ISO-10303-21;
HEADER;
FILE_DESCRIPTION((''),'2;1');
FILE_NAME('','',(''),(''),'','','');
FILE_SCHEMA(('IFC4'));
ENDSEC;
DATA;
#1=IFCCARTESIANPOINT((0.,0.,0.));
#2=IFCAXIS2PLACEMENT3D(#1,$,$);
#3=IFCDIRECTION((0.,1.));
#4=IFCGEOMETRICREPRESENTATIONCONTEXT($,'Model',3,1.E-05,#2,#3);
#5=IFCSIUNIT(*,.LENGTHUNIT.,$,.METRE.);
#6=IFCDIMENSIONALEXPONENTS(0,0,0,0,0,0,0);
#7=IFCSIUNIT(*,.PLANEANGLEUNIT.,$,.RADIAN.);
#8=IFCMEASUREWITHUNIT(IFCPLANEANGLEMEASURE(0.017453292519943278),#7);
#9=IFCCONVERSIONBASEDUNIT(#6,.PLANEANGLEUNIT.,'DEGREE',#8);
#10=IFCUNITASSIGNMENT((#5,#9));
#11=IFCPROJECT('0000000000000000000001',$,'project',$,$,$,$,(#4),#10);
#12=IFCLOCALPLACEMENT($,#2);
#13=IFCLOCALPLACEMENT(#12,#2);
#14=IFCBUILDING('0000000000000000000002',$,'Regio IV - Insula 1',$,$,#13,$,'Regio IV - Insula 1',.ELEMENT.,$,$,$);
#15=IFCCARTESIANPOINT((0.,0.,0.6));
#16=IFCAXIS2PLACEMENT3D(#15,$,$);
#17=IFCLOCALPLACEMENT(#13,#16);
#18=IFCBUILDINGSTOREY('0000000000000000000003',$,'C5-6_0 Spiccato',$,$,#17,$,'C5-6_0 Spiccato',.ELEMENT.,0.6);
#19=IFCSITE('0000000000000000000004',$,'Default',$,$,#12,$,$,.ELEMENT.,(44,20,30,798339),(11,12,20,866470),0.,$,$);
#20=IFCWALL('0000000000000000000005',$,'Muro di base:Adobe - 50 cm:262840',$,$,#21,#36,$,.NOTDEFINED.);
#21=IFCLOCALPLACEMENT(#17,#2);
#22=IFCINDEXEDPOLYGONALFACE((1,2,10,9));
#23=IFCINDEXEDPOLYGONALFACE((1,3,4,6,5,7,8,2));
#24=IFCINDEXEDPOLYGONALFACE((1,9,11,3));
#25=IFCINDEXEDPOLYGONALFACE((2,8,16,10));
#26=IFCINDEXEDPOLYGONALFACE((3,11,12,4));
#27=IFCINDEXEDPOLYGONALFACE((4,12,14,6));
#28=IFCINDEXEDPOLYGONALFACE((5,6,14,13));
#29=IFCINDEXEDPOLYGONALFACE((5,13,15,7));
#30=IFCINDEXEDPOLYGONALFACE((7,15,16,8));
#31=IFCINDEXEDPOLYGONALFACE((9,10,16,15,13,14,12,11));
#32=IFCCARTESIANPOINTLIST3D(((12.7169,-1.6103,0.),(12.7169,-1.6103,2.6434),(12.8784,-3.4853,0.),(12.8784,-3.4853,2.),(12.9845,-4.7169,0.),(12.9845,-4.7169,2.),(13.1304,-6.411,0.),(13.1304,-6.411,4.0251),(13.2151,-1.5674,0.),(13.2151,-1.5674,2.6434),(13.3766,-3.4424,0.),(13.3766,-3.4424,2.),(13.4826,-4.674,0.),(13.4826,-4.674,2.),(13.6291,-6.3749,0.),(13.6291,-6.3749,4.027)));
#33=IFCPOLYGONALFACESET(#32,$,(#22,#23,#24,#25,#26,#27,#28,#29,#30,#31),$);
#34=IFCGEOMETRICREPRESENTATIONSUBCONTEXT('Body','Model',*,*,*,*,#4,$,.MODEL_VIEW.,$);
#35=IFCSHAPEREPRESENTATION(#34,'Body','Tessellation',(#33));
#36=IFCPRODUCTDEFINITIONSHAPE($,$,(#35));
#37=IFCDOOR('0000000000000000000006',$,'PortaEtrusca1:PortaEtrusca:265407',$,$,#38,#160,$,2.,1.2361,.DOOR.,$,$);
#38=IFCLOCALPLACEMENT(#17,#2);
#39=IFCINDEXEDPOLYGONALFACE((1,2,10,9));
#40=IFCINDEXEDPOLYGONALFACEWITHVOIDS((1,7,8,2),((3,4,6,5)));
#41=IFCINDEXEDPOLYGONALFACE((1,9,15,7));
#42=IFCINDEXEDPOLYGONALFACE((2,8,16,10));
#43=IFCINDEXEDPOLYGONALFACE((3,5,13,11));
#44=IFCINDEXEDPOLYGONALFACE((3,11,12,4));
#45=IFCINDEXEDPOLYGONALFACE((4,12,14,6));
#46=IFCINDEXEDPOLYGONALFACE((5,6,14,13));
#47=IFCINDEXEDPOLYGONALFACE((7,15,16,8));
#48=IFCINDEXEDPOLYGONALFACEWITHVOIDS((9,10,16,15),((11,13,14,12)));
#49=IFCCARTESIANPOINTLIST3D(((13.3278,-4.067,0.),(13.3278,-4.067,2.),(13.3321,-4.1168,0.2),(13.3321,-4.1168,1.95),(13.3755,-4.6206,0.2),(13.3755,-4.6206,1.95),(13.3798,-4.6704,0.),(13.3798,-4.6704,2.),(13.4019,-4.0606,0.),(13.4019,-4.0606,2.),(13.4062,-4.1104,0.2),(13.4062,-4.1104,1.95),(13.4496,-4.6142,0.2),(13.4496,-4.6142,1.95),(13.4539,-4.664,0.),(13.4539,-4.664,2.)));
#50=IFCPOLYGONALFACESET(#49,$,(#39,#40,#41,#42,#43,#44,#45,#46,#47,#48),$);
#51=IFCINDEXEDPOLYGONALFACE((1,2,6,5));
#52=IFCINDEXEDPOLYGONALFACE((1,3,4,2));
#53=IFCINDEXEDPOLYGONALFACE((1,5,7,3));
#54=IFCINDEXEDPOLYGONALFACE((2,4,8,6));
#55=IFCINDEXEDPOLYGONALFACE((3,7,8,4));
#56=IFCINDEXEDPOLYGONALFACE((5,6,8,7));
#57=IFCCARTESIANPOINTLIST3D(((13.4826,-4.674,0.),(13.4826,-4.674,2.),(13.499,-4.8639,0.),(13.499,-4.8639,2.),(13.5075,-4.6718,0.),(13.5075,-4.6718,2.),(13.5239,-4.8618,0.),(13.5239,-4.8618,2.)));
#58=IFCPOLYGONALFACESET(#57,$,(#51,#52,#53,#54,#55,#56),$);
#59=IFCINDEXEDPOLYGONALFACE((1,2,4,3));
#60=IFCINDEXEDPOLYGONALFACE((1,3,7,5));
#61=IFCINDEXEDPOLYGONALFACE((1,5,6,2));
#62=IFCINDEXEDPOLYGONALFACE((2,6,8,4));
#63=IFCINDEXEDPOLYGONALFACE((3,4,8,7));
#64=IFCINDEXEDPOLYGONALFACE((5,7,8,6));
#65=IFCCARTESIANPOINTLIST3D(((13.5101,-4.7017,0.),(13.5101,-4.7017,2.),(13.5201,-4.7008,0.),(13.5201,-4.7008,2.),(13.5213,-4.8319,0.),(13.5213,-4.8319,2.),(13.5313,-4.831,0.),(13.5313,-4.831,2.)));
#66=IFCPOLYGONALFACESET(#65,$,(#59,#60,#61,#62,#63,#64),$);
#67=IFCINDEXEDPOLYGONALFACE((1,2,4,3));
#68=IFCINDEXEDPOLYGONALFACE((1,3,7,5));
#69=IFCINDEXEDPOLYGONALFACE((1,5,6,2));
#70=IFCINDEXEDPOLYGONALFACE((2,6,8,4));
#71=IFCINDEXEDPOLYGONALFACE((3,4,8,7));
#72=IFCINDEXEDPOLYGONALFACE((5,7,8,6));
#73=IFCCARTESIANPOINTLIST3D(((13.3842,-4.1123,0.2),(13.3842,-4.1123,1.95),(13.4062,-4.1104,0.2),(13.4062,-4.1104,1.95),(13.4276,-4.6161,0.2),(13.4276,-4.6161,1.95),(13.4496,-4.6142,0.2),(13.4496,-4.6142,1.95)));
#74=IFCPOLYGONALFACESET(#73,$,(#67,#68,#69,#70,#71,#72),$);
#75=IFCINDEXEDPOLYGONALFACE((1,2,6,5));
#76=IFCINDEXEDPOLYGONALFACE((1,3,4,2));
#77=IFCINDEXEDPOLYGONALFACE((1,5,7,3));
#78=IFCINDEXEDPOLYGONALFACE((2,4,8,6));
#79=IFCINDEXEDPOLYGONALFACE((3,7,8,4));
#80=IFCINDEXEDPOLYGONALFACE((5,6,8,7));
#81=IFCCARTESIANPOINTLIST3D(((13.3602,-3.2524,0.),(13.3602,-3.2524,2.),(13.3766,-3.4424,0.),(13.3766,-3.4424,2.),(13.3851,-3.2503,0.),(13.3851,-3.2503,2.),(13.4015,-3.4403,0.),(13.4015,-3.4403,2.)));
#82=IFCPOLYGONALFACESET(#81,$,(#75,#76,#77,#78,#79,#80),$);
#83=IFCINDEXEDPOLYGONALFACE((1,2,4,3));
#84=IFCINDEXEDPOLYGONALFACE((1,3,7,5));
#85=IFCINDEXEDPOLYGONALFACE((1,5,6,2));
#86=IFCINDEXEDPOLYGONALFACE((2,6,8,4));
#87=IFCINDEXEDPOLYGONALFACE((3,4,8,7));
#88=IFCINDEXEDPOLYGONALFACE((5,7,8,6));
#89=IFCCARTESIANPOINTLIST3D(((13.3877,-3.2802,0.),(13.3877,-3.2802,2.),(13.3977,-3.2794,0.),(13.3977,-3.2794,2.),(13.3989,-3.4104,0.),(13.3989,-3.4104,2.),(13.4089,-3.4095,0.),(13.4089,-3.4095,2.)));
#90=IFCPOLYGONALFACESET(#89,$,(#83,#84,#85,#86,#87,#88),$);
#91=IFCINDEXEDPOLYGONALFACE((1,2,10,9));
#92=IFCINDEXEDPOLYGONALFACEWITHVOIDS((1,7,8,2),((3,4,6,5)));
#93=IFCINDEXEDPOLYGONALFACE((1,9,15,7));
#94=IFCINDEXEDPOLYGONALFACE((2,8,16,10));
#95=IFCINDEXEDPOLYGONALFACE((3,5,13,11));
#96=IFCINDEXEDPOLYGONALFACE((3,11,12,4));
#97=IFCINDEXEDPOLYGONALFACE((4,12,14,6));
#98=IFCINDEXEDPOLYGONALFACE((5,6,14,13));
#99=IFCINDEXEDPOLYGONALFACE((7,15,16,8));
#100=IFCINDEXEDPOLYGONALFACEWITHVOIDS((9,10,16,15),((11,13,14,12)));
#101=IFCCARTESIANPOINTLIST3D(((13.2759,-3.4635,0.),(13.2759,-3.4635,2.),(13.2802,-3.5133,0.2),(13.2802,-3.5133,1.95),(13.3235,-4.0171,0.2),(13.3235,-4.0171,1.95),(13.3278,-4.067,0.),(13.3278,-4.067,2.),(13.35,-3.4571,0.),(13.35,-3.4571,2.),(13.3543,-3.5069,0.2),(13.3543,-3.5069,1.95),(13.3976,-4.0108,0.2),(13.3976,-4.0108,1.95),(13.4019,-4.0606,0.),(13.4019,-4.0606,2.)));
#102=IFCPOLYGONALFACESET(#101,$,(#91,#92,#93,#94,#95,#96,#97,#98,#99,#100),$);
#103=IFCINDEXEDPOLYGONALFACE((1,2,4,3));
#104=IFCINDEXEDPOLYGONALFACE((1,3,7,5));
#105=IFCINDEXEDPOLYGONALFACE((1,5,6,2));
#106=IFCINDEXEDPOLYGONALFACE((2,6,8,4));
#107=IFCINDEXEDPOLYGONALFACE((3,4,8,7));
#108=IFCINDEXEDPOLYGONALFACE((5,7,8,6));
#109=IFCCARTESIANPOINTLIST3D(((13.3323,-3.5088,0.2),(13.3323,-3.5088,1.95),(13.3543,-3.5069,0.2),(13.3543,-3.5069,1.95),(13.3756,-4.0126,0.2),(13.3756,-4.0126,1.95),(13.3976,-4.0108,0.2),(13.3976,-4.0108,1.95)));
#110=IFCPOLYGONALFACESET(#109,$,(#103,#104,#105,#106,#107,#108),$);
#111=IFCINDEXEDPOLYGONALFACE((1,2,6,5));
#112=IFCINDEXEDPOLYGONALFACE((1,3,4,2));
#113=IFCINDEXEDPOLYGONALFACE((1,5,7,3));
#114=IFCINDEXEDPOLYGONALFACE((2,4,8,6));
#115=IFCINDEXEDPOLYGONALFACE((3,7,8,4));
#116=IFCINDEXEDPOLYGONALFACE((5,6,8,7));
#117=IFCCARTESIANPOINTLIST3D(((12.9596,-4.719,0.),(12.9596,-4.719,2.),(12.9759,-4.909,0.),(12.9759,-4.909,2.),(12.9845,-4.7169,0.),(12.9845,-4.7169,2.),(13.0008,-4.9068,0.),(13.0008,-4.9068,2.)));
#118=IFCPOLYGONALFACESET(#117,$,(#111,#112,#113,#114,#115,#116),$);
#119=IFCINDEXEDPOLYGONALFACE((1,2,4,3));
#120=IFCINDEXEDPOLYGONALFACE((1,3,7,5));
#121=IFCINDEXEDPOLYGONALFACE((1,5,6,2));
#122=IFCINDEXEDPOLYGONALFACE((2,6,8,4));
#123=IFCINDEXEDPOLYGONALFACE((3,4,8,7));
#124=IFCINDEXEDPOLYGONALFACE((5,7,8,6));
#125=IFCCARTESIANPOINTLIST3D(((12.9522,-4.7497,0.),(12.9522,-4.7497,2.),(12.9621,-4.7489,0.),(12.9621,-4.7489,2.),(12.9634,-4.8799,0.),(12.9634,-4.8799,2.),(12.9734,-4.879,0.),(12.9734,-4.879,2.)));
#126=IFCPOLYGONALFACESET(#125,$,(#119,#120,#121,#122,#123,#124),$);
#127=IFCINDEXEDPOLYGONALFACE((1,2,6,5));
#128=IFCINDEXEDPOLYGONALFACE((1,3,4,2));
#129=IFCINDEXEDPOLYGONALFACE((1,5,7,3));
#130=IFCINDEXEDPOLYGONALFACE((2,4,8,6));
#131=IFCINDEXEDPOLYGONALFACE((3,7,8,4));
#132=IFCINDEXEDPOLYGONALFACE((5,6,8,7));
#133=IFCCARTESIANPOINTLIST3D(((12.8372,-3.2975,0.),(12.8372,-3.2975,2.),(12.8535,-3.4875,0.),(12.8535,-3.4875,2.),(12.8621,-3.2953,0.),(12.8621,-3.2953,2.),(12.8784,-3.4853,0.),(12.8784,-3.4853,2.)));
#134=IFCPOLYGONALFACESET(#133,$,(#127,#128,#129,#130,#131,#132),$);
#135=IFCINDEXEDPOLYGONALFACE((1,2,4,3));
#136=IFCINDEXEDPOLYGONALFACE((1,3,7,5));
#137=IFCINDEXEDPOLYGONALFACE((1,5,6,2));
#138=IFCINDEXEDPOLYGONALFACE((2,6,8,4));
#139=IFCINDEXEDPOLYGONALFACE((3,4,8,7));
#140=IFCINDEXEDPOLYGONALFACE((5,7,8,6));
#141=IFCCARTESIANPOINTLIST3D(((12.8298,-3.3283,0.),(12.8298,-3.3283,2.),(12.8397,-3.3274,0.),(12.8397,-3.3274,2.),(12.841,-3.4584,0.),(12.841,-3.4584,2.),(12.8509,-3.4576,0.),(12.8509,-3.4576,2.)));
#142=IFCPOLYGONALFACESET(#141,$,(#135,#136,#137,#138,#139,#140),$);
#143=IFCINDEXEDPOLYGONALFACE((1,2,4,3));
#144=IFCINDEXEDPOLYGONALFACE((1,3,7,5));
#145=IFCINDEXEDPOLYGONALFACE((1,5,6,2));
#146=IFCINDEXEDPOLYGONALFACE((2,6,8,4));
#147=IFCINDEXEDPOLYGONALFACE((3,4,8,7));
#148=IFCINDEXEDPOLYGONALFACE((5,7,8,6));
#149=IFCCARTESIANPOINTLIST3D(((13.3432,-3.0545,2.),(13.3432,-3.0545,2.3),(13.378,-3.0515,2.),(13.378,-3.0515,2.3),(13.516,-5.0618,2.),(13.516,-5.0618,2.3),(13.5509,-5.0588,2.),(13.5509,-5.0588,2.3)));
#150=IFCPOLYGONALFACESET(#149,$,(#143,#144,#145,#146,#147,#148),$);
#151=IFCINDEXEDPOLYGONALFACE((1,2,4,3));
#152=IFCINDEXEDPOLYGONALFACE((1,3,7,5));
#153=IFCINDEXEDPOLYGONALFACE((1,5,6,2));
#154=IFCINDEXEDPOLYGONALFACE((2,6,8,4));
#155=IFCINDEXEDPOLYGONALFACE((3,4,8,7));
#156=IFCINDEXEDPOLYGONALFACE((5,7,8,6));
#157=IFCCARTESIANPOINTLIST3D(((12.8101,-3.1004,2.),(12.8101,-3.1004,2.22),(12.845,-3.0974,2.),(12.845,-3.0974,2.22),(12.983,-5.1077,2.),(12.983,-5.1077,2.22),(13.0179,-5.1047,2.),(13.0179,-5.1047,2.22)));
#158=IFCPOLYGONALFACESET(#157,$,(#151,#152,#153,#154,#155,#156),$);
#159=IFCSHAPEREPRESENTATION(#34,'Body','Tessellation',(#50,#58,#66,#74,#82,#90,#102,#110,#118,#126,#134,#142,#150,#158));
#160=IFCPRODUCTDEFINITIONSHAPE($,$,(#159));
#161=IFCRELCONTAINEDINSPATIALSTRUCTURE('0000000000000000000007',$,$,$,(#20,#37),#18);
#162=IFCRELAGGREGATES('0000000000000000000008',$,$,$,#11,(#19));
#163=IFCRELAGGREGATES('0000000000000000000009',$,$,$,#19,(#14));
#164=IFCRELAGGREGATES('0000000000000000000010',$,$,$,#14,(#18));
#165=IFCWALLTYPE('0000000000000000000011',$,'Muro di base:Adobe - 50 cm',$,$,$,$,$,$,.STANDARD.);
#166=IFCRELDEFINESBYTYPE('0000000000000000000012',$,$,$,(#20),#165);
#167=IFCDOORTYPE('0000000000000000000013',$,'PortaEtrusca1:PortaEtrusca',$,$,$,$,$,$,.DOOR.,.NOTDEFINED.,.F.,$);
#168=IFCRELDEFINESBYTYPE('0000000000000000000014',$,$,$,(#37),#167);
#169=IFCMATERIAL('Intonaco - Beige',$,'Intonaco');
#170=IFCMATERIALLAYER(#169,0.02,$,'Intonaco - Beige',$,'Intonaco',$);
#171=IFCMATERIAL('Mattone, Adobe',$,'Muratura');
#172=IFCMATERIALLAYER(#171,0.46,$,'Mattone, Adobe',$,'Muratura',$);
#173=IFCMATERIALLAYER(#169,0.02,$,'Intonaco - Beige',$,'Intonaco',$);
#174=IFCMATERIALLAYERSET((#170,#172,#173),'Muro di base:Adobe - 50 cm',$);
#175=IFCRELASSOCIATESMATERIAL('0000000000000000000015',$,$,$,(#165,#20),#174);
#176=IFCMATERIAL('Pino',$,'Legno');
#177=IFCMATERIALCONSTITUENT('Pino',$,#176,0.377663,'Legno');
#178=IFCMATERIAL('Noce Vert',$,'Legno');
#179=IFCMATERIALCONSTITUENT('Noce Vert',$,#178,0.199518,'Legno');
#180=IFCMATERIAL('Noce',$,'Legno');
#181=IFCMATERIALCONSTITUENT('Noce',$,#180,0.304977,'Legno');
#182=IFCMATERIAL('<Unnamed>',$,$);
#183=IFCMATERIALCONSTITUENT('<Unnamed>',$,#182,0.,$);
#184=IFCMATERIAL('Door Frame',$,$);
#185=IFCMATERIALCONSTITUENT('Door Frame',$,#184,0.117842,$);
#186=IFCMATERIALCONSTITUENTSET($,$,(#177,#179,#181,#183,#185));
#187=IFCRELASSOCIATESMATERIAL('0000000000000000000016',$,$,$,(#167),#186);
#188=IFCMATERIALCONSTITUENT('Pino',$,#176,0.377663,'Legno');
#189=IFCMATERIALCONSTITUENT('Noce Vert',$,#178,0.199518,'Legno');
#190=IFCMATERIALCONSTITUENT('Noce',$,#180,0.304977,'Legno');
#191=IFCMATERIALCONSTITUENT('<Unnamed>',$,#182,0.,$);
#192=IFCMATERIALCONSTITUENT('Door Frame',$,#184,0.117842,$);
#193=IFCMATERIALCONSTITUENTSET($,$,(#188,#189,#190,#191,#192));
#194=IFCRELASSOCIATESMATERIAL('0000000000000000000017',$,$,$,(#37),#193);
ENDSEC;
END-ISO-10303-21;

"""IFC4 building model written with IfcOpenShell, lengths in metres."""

from ifc_helpers import new_model, entity, si_unit, converted_unit, direction, frame, frame_2d, origin, origin_2d_with_axis, place, context, subcontext, project, spatial, polyline, rectangle, outline, extrude, clip, bounded_halfspace, source, transform, mapped, material, layer, layer_set, layer_usage, constituent, constituent_set, type_object, type_shapes, element, fill, save


model = new_model("IFC4")

# Units and contexts
model_context = context("Model", 3, precision=1e-05, world=origin(), true_north=direction((0.0, 1.0)))
body_context = subcontext(model_context, "Body", "Model", "MODEL_VIEW")
ifc_project = project(units=[si_unit("LENGTHUNIT", "METRE"), converted_unit("PLANEANGLEUNIT", "DEGREE", entity("IfcPlaneAngleMeasure", 0.017453292519943278), si_unit("PLANEANGLEUNIT", "RADIAN"), dimensions=[0, 0, 0, 0, 0, 0, 0])], contexts=[model_context])

# Site, building, storey
site_placement = place(None, origin())
site = spatial("IfcSite", under=ifc_project, at=site_placement, Name="Default", CompositionType="ELEMENT", RefLatitude=(44, 20, 30, 798339), RefLongitude=(11, 12, 20, 866470), RefElevation=0.0)
building_placement = place(site_placement, origin())
building = spatial("IfcBuilding", under=site, at=building_placement, Name="Regio IV - Insula 1", LongName="Regio IV - Insula 1", CompositionType="ELEMENT")
storey_placement = place(building_placement, frame((0.0, 0.0, 0.6)))
storey = spatial("IfcBuildingStorey", under=building, at=storey_placement, Name="C5-6_0 Spiccato", LongName="C5-6_0 Spiccato", CompositionType="ELEMENT", Elevation=0.6)

# Shared definitions
ifc_material_1 = material(Name="Intonaco - Beige", Category="Intonaco")
ifc_material_2 = material(Name="Mattone, Adobe", Category="Muratura")
ifc_layer_1 = layer(ifc_material_1, 0.02, Name="Intonaco - Beige", Category="Intonaco")
ifc_layer_2 = layer(ifc_material_2, 0.46, Name="Mattone, Adobe", Category="Muratura")
ifc_layer_3 = layer(ifc_material_1, 0.02, Name="Intonaco - Beige", Category="Intonaco")
ifc_layer_set_1 = layer_set([ifc_layer_1, ifc_layer_2, ifc_layer_3], Name="Muro di base:Adobe - 50 cm")
wall_type_1 = type_object("IfcWallType", Name="Muro di base:Adobe - 50 cm", PredefinedType="STANDARD", material=ifc_layer_set_1)

# Shared definitions
ifc_material_3 = material(Name="Pino", Category="Legno")
ifc_material_4 = material(Name="Noce Vert", Category="Legno")
ifc_material_5 = material(Name="Noce", Category="Legno")
ifc_material_6 = material(Name="<Unnamed>")
ifc_material_7 = material(Name="Door Frame")
ifc_constituent_1 = constituent(ifc_material_3, Name="Pino", Category="Legno", fraction=0.377663)
ifc_constituent_2 = constituent(ifc_material_4, Name="Noce Vert", Category="Legno", fraction=0.199518)
ifc_constituent_3 = constituent(ifc_material_5, Name="Noce", Category="Legno", fraction=0.304977)
ifc_constituent_4 = constituent(ifc_material_6, Name="<Unnamed>", fraction=0.0)
ifc_constituent_5 = constituent(ifc_material_7, Name="Door Frame", fraction=0.117842)
ifc_constituent_set_1 = constituent_set(constituents=[ifc_constituent_1, ifc_constituent_2, ifc_constituent_3, ifc_constituent_4, ifc_constituent_5])
door_type = type_object("IfcDoorType", Name="PortaEtrusca1:PortaEtrusca", OperationType="NOTDEFINED", ParameterTakesPrecedence=False, PredefinedType="DOOR", material=ifc_constituent_set_1)
shared_shape = source(origin(), body_context, "Body", "SweptSolid", [
    extrude(outline(polyline([(-1.0, -0.3028), (1.0, -0.3028), (1.0, 0.3028), (-1.0, 0.3028), (-1.0, -0.3028)]), holes=[polyline([(-0.95, 0.2528), (0.8, 0.2528), (0.8, -0.2528), (-0.95, -0.2528), (-0.95, 0.2528)])]), frame((0.3152, 0.0278, 1.0), z_axis=(0.0, 1.0, 0.0), x_axis=(0.0, 0.0, -1.0)), (0.0, 0.0, 1.0), 0.0744),
    extrude(rectangle(XDim=0.025, YDim=0.1907, at=frame_2d((0.0, 0.0), x_axis=(1.0, 0.0))), frame((-0.0953, -0.0125, 0.0), z_axis=(0.0, 0.0, 1.0), x_axis=(0.0, 1.0, 0.0)), (0.0, 0.0, 1.0), 2.0),
    extrude(rectangle(XDim=0.01, YDim=0.1306, at=frame_2d((0.0, 0.0), x_axis=(1.0, 0.0))), frame((-0.0953, -0.03, 0.0), z_axis=(0.0, 0.0, 1.0), x_axis=(0.0, 1.0, 0.0)), (0.0, 0.0, 1.0), 2.0),
    extrude(rectangle(XDim=0.0221, YDim=0.5057, at=frame_2d((0.0, 0.0), x_axis=(1.0, 0.0))), frame((0.3152, 0.0388, 0.2), z_axis=(0.0, 0.0, 1.0), x_axis=(0.0, 1.0, 0.0)), (0.0, 0.0, 1.0), 1.75),
    extrude(rectangle(XDim=0.025, YDim=0.1907, at=frame_2d((0.0, 0.0), x_axis=(1.0, 0.0))), frame((1.3314, -0.0125, 0.0), z_axis=(0.0, 0.0, 1.0), x_axis=(0.0, 1.0, 0.0)), (0.0, 0.0, 1.0), 2.0),
    extrude(rectangle(XDim=0.01, YDim=0.1306, at=frame_2d((0.0, 0.0), x_axis=(1.0, 0.0))), frame((1.3314, -0.03, 0.0), z_axis=(0.0, 0.0, 1.0), x_axis=(0.0, 1.0, 0.0)), (0.0, 0.0, 1.0), 2.0),
    extrude(outline(polyline([(-0.3028, -1.0), (0.3028, -1.0), (0.3028, 1.0), (-0.3028, 1.0), (-0.3028, -1.0)]), holes=[polyline([(0.2528, -0.95), (-0.2528, -0.95), (-0.2528, 0.8), (0.2528, 0.8), (0.2528, -0.95)])]), frame((0.9209, 0.0278, 1.0), z_axis=(0.0, 1.0, 0.0), x_axis=(1.0, 0.0, 0.0)), (0.0, 0.0, 1.0), 0.0744),
    extrude(rectangle(XDim=0.0221, YDim=0.5057, at=frame_2d((0.0, 0.0), x_axis=(1.0, 0.0))), frame((0.9209, 0.0388, 0.2), z_axis=(0.0, 0.0, 1.0), x_axis=(0.0, 1.0, 0.0)), (0.0, 0.0, 1.0), 1.75),
    extrude(rectangle(XDim=0.025, YDim=0.1907, at=frame_2d((0.0, 0.0), x_axis=(1.0, 0.0))), frame((-0.0953, 0.5125, 0.0), z_axis=(0.0, 0.0, 1.0), x_axis=(0.0, -1.0, 0.0)), (0.0, 0.0, 1.0), 2.0),
    extrude(rectangle(XDim=0.01, YDim=0.1306, at=frame_2d((0.0, 0.0), x_axis=(1.0, 0.0))), frame((-0.0953, 0.53, 0.0), z_axis=(0.0, 0.0, 1.0), x_axis=(0.0, -1.0, 0.0)), (0.0, 0.0, 1.0), 2.0),
    extrude(rectangle(XDim=0.025, YDim=0.1907, at=frame_2d((0.0, 0.0), x_axis=(1.0, 0.0))), frame((1.3314, 0.5125, 0.0), z_axis=(0.0, 0.0, 1.0), x_axis=(0.0, -1.0, 0.0)), (0.0, 0.0, 1.0), 2.0),
    extrude(rectangle(XDim=0.01, YDim=0.1306, at=frame_2d((0.0, 0.0), x_axis=(1.0, 0.0))), frame((1.3314, 0.53, 0.0), z_axis=(0.0, 0.0, 1.0), x_axis=(0.0, -1.0, 0.0)), (0.0, 0.0, 1.0), 2.0),
    extrude(rectangle(XDim=0.035, YDim=2.0147, at=origin_2d_with_axis()), frame((0.618, -0.0175, 2.0), z_axis=(0.0, 0.0, 1.0), x_axis=(0.0, 1.0, 0.0)), (0.0, 0.0, 1.0), 0.3),
    extrude(rectangle(XDim=0.035, YDim=2.0147, at=origin_2d_with_axis()), frame((0.618, 0.5175, 2.0), z_axis=(0.0, 0.0, 1.0), x_axis=(0.0, -1.0, 0.0)), (0.0, 0.0, 1.0), 0.22),
])
type_shapes(door_type, [shared_shape])

# Wall, opening, door
ifc_layer_usage_1 = layer_usage(ifc_layer_set_1, "AXIS2", "NEGATIVE", 0.25)
wall_1_placement = place(storey_placement, frame((13.38, -6.3964, 0.0), z_axis=(0.0, 0.0, 1.0), x_axis=(-0.085801, 0.996312, 0.0)))
wall_1 = element("IfcWall", 1, at=wall_1_placement, inside=storey, type_object=wall_type_1, material=ifc_layer_usage_1, Name="Muro di base:Adobe - 50 cm:262840", PredefinedType="NOTDEFINED", context=body_context, shape_type="Clipping", body=[
    clip(extrude(outline(polyline([(0.0, -0.25), (4.8253, -0.25), (4.8253, 0.25), (0.6069, 0.25), (0.0068, 0.25), (0.0, -0.25)])), origin(), (0.0, 0.0, 1.0), 4.027), bounded_halfspace(frame((0.0, -0.25, 4.027), z_axis=(0.275637, 0.0, 0.961262), x_axis=(0.0, 1.0, 0.0)), False, frame((0.0, -0.25, 4.027)), polyline([(0.0, 0.0), (4.8253, 0.0), (4.8253, 0.5), (0.6069, 0.5), (0.0068, 0.5), (0.0, 0.0)]))),
])
opening_1_placement = place(wall_1_placement, frame((1.7073, -0.25, 0.0)))
opening_1 = element("IfcOpeningElement", 2, at=opening_1_placement, cuts=wall_1, PredefinedType="OPENING", context=body_context, shape_type="SweptSolid", body=[
    extrude(rectangle(XDim=2.0, YDim=1.2361, at=frame_2d((1.0, 0.618), x_axis=(1.0, 0.0))), frame((0.0, 0.0, 0.0), z_axis=(0.0, 1.0, 0.0), x_axis=(0.0, 0.0, 1.0)), (0.0, 0.0, 1.0), 0.5),
])
ifc_constituent_6 = constituent(ifc_material_3, Name="Pino", Category="Legno", fraction=0.377663)
ifc_constituent_7 = constituent(ifc_material_4, Name="Noce Vert", Category="Legno", fraction=0.199518)
ifc_constituent_8 = constituent(ifc_material_5, Name="Noce", Category="Legno", fraction=0.304977)
ifc_constituent_9 = constituent(ifc_material_6, Name="<Unnamed>", fraction=0.0)
ifc_constituent_10 = constituent(ifc_material_7, Name="Door Frame", fraction=0.117842)
ifc_constituent_set_2 = constituent_set(constituents=[ifc_constituent_6, ifc_constituent_7, ifc_constituent_8, ifc_constituent_9, ifc_constituent_10])
door_1_placement = place(opening_1_placement, origin())
door_1 = element("IfcDoor", 3, at=door_1_placement, inside=storey, type_object=door_type, material=ifc_constituent_set_2, Name="PortaEtrusca1:PortaEtrusca:265407", OverallHeight=2.0, OverallWidth=1.2361, PredefinedType="DOOR", context=body_context, shape_type="MappedRepresentation", body=[
    mapped(shared_shape, transform((0.0, 0.0, 0.0), scale=1.0)),
])
fill(opening_1, door_1)

save(model, "model.ifc")
